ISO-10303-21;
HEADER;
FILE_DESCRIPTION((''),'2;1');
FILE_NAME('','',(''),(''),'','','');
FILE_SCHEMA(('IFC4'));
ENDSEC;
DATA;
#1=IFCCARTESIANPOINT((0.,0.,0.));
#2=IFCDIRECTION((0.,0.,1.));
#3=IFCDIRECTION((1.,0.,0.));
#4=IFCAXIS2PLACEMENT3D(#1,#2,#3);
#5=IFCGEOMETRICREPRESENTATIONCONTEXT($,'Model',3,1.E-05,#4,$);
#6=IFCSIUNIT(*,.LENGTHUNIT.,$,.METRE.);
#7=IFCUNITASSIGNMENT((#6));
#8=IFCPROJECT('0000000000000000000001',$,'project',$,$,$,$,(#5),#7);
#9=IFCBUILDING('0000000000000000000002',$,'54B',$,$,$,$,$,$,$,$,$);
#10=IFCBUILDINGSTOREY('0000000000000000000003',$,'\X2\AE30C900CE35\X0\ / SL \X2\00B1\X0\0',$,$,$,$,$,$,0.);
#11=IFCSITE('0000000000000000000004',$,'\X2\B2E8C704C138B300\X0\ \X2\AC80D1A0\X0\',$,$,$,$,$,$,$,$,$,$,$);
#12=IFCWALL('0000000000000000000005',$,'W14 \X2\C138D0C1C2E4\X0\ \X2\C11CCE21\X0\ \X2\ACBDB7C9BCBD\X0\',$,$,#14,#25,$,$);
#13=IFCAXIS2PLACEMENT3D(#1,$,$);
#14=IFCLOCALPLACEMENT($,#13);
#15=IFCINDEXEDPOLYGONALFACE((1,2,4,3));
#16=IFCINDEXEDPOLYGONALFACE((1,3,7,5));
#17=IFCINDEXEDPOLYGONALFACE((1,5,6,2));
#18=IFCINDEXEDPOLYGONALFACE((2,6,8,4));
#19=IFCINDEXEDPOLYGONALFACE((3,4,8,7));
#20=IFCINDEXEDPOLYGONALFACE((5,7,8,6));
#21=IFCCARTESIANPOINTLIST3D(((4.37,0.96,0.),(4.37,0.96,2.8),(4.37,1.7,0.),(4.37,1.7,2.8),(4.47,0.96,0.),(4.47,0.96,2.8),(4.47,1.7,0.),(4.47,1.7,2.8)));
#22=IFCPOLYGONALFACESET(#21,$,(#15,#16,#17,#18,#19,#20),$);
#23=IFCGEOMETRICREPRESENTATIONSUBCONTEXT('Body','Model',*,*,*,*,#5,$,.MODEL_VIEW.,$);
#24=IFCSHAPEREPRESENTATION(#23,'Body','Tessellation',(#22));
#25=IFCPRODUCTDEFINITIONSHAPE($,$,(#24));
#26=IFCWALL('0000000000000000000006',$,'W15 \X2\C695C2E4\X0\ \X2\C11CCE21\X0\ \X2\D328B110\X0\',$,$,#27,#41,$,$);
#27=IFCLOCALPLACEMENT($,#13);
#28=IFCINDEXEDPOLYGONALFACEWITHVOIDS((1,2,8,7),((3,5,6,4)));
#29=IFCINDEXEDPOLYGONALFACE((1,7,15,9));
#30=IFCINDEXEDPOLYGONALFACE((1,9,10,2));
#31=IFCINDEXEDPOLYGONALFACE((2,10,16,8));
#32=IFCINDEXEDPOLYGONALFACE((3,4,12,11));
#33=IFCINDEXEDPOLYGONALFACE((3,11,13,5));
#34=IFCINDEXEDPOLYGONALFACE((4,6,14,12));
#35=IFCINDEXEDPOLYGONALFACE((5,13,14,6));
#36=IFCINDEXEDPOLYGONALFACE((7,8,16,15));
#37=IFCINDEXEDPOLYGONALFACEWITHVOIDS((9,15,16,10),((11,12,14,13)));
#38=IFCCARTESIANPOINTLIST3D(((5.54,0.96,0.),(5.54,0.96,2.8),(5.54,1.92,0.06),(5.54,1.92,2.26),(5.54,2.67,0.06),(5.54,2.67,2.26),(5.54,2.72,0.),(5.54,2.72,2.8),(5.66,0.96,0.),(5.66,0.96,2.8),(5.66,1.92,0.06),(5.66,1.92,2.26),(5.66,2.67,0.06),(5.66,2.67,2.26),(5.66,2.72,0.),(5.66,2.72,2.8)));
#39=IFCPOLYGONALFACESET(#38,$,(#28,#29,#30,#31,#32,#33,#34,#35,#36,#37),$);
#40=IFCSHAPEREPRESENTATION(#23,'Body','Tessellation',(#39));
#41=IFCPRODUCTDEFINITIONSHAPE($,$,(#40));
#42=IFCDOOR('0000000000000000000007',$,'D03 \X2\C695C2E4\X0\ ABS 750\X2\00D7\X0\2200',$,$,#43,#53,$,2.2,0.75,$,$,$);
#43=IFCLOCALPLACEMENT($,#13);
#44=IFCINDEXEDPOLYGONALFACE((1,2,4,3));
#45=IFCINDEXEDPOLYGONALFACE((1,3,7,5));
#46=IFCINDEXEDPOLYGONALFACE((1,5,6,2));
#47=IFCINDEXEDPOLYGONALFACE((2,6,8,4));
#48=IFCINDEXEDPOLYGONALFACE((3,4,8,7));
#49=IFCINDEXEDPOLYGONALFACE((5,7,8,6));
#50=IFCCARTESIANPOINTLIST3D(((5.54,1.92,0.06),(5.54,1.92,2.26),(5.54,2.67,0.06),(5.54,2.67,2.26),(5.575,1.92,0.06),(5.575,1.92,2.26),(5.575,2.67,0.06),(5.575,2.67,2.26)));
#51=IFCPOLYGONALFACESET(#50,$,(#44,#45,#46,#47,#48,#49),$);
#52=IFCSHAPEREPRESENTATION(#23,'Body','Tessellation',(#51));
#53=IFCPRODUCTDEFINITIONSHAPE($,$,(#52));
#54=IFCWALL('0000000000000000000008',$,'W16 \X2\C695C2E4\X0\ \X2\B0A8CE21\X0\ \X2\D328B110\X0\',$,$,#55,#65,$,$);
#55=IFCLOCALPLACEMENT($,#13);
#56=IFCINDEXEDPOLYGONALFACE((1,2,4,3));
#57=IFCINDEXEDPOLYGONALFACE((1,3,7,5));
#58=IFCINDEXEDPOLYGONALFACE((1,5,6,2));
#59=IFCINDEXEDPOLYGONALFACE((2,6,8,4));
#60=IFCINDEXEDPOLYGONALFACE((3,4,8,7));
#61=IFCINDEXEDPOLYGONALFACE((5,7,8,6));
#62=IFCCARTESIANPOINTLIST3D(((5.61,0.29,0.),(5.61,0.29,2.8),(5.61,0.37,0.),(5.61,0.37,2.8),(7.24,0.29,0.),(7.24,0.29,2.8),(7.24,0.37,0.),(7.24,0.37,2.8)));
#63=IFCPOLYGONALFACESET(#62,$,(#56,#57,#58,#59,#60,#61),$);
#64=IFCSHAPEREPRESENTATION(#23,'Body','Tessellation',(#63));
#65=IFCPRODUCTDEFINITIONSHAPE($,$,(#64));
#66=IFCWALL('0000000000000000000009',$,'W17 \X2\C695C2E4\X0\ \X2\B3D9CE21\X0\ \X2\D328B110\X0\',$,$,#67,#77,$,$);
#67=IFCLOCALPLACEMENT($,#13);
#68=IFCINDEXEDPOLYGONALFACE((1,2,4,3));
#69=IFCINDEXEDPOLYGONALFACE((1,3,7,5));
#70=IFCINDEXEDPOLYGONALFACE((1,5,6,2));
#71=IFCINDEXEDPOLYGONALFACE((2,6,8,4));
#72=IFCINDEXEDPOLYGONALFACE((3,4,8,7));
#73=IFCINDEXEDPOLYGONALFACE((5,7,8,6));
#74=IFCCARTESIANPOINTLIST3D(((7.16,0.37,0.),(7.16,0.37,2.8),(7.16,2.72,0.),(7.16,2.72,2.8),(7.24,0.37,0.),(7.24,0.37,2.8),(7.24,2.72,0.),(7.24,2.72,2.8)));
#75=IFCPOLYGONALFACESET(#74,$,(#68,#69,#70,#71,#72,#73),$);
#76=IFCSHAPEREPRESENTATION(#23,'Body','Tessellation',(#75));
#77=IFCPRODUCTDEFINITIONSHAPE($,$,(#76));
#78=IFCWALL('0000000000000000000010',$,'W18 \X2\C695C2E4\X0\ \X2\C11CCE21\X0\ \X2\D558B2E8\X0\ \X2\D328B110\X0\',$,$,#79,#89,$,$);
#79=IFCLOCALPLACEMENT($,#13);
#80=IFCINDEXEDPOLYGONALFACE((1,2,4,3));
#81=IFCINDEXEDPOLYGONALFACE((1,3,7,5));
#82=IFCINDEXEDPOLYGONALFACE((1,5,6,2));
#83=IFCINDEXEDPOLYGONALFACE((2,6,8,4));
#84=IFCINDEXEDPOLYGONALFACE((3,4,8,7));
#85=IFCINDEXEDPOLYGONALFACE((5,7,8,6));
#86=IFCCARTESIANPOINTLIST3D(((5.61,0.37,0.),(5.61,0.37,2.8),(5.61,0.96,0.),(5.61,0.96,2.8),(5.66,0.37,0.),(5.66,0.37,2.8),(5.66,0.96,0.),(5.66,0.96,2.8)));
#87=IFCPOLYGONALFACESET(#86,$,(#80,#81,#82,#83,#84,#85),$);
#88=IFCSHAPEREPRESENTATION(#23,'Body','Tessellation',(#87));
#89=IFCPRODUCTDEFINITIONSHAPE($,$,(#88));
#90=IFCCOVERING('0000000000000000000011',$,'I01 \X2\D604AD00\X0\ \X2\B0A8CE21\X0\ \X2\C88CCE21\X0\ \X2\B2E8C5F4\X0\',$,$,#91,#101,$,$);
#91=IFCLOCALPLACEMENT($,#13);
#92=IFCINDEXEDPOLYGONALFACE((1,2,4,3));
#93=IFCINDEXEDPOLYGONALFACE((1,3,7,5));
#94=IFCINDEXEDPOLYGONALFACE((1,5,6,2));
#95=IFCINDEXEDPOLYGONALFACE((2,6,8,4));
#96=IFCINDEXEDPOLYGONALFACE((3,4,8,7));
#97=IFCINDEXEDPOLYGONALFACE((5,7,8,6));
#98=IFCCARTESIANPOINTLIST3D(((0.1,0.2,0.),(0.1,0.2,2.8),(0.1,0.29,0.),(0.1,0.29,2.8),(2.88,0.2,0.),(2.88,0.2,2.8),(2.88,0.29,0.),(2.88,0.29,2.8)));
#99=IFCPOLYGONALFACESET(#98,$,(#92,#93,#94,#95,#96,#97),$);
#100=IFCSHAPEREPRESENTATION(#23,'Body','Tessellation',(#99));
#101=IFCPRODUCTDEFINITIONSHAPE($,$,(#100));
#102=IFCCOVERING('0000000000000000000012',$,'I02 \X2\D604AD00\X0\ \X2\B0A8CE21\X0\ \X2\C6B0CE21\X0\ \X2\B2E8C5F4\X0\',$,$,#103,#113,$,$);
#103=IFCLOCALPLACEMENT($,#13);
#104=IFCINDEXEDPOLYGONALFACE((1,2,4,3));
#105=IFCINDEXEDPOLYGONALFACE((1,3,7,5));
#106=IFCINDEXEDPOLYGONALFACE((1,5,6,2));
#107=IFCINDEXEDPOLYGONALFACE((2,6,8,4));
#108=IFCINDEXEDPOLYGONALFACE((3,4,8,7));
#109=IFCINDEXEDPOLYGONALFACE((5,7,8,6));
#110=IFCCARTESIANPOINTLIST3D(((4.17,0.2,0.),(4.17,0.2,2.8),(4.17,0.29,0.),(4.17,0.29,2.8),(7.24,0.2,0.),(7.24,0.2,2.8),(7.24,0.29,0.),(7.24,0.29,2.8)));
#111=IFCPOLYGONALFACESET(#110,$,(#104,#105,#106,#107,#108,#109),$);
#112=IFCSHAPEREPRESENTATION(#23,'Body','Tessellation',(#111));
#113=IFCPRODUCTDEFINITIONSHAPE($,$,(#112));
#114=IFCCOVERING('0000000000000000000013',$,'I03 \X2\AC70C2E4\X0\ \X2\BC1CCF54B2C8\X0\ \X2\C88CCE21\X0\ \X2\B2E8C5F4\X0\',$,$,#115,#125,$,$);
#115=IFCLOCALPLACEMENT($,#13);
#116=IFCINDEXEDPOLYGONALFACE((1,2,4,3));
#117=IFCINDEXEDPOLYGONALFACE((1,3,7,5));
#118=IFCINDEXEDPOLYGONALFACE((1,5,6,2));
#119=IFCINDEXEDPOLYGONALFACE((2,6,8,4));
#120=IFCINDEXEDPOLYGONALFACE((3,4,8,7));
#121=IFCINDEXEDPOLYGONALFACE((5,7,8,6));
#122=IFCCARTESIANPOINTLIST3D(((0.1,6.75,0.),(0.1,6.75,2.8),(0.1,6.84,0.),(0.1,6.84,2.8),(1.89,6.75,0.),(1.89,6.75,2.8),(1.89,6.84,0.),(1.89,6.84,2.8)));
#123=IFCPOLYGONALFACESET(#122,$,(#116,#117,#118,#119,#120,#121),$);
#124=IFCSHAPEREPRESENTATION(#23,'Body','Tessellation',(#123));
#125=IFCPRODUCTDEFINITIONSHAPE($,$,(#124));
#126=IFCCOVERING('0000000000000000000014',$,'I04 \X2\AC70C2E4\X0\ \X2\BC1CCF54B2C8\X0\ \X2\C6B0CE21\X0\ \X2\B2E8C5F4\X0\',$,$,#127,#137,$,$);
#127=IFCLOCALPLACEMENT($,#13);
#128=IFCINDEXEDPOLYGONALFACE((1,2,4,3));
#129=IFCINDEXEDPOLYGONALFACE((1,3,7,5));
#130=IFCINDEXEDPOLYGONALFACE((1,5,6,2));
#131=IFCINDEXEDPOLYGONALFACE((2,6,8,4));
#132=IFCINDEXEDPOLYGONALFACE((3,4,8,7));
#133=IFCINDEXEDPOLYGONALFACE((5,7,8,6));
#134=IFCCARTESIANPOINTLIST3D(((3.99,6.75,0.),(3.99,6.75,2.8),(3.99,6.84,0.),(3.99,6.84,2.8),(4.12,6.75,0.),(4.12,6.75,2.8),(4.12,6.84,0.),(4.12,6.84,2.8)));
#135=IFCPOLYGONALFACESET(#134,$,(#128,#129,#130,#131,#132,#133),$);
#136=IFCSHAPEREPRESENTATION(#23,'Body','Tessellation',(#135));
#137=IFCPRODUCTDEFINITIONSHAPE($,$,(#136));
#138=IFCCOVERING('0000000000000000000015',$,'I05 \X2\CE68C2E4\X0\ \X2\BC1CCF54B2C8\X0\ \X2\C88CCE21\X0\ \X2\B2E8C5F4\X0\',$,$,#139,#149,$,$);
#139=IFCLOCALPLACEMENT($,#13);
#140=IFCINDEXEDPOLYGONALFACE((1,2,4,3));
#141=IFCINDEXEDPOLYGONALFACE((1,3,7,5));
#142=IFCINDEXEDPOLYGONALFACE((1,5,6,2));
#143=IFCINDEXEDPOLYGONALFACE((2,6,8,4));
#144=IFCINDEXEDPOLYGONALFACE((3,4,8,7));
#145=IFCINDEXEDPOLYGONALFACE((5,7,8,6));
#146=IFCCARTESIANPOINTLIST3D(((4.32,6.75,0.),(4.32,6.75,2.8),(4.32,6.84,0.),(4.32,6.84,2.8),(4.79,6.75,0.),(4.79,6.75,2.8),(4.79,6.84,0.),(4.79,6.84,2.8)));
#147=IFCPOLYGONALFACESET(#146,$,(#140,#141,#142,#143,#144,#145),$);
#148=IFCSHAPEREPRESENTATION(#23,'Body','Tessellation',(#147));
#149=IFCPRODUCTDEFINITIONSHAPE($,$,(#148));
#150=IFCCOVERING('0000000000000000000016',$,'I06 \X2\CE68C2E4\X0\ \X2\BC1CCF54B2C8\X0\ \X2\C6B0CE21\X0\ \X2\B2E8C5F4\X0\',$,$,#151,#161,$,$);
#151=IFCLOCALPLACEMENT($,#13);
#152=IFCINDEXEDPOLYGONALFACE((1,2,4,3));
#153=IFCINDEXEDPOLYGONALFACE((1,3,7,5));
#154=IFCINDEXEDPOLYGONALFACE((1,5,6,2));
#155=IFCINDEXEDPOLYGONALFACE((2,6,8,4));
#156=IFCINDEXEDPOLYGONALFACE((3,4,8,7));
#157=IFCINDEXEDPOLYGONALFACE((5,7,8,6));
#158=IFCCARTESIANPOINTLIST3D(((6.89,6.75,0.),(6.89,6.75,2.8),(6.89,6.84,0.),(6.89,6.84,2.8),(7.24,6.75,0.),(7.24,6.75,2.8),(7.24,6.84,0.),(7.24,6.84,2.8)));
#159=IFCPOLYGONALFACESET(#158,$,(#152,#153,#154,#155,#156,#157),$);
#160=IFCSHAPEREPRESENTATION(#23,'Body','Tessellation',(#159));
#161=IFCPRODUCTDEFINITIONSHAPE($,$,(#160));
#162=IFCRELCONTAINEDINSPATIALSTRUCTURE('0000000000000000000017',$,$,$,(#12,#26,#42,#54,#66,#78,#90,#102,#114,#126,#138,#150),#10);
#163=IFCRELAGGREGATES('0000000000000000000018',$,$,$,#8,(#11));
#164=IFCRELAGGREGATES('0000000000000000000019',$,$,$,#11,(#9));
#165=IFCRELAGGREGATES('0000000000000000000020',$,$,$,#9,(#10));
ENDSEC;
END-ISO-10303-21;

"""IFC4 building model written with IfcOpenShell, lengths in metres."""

from ifc_helpers import new_model, si_unit, frame, origin, origin_with_axes, place, context, subcontext, project, spatial, polyline, outline, extrude, element, fill, save


model = new_model("IFC4")

# Units and contexts
model_context = context("Model", 3, precision=1e-05, world=origin_with_axes())
body_context = subcontext(model_context, "Body", "Model", "MODEL_VIEW")
ifc_project = project(units=[si_unit("LENGTHUNIT", "METRE")], contexts=[model_context])

# Site, building, storey
site = spatial("IfcSite", under=ifc_project, Name="단위세대 검토")
building = spatial("IfcBuilding", under=site, Name="54B")
storey = spatial("IfcBuildingStorey", under=building, Name="기준층 / SL ±0", Elevation=0.0)

# Wall
wall_1_placement = place(None, origin_with_axes())
element("IfcWall", 1, at=wall_1_placement, inside=storey, Name="W14 세탁실 서측 경량벽", context=body_context, shape_type="SweptSolid", body=[
    extrude(outline(polyline([(4.47, 0.96), (4.47, 1.7), (4.37, 1.7), (4.37, 0.96), (4.47, 0.96)])), origin(), (0.0, 0.0, 1.0), 2.8),
])

# Wall, opening, door
wall_2_placement = place(None, origin_with_axes())
wall_2 = element("IfcWall", 2, at=wall_2_placement, inside=storey, Name="W15 욕실 서측 패널", context=body_context, shape_type="SweptSolid", body=[
    extrude(outline(polyline([(5.66, 0.96), (5.66, 2.72), (5.54, 2.72), (5.54, 0.96), (5.66, 0.96)])), origin(), (0.0, 0.0, 1.0), 2.8),
])
opening_placement = place(wall_2_placement, origin_with_axes())
opening = element("IfcOpeningElement", 3, at=opening_placement, cuts=wall_2, context=body_context, shape_type="SweptSolid", body=[
    extrude(outline(polyline([(5.661, 1.92), (5.661, 2.67), (5.539, 2.67), (5.539, 1.92), (5.661, 1.92)])), frame((0.0, 0.0, 0.06)), (0.0, 0.0, 1.0), 2.2),
])
door_placement = place(None, origin_with_axes())
door = element("IfcDoor", 4, at=door_placement, inside=storey, Name="D03 욕실 ABS 750×2200", OverallHeight=2.2, OverallWidth=0.75, context=body_context, shape_type="SweptSolid", body=[
    extrude(outline(polyline([(5.575, 1.92), (5.575, 2.67), (5.54, 2.67), (5.54, 1.92), (5.575, 1.92)])), frame((0.0, 0.0, 0.06)), (0.0, 0.0, 1.0), 2.2),
])
fill(opening, door)

# Walls
wall_3_placement = place(None, origin_with_axes())
element("IfcWall", 5, at=wall_3_placement, inside=storey, Name="W16 욕실 남측 패널", context=body_context, shape_type="SweptSolid", body=[
    extrude(outline(polyline([(7.24, 0.29), (7.24, 0.37), (5.61, 0.37), (5.61, 0.29), (7.24, 0.29)])), origin(), (0.0, 0.0, 1.0), 2.8),
])
wall_4_placement = place(None, origin_with_axes())
element("IfcWall", 6, at=wall_4_placement, inside=storey, Name="W17 욕실 동측 패널", context=body_context, shape_type="SweptSolid", body=[
    extrude(outline(polyline([(7.24, 0.37), (7.24, 2.72), (7.16, 2.72), (7.16, 0.37), (7.24, 0.37)])), origin(), (0.0, 0.0, 1.0), 2.8),
])
wall_5_placement = place(None, origin_with_axes())
element("IfcWall", 7, at=wall_5_placement, inside=storey, Name="W18 욕실 서측 하단 패널", context=body_context, shape_type="SweptSolid", body=[
    extrude(outline(polyline([(5.66, 0.37), (5.66, 0.96), (5.61, 0.96), (5.61, 0.37), (5.66, 0.37)])), origin(), (0.0, 0.0, 1.0), 2.8),
])

# Coverings
covering_1_placement = place(None, origin_with_axes())
element("IfcCovering", 8, at=covering_1_placement, inside=storey, Name="I01 현관 남측 좌측 단열", context=body_context, shape_type="SweptSolid", body=[
    extrude(outline(polyline([(2.88, 0.2), (2.88, 0.29), (0.1, 0.29), (0.1, 0.2), (2.88, 0.2)])), origin(), (0.0, 0.0, 1.0), 2.8),
])
covering_2_placement = place(None, origin_with_axes())
element("IfcCovering", 9, at=covering_2_placement, inside=storey, Name="I02 현관 남측 우측 단열", context=body_context, shape_type="SweptSolid", body=[
    extrude(outline(polyline([(7.24, 0.2), (7.24, 0.29), (4.17, 0.29), (4.17, 0.2), (7.24, 0.2)])), origin(), (0.0, 0.0, 1.0), 2.8),
])
covering_3_placement = place(None, origin_with_axes())
element("IfcCovering", 10, at=covering_3_placement, inside=storey, Name="I03 거실 발코니 좌측 단열", context=body_context, shape_type="SweptSolid", body=[
    extrude(outline(polyline([(1.89, 6.75), (1.89, 6.84), (0.1, 6.84), (0.1, 6.75), (1.89, 6.75)])), origin(), (0.0, 0.0, 1.0), 2.8),
])
covering_4_placement = place(None, origin_with_axes())
element("IfcCovering", 11, at=covering_4_placement, inside=storey, Name="I04 거실 발코니 우측 단열", context=body_context, shape_type="SweptSolid", body=[
    extrude(outline(polyline([(4.12, 6.75), (4.12, 6.84), (3.99, 6.84), (3.99, 6.75), (4.12, 6.75)])), origin(), (0.0, 0.0, 1.0), 2.8),
])
covering_5_placement = place(None, origin_with_axes())
element("IfcCovering", 12, at=covering_5_placement, inside=storey, Name="I05 침실 발코니 좌측 단열", context=body_context, shape_type="SweptSolid", body=[
    extrude(outline(polyline([(4.79, 6.75), (4.79, 6.84), (4.32, 6.84), (4.32, 6.75), (4.79, 6.75)])), origin(), (0.0, 0.0, 1.0), 2.8),
])
covering_6_placement = place(None, origin_with_axes())
element("IfcCovering", 13, at=covering_6_placement, inside=storey, Name="I06 침실 발코니 우측 단열", context=body_context, shape_type="SweptSolid", body=[
    extrude(outline(polyline([(7.24, 6.75), (7.24, 6.84), (6.89, 6.84), (6.89, 6.75), (7.24, 6.75)])), origin(), (0.0, 0.0, 1.0), 2.8),
])

save(model, "model.ifc")
